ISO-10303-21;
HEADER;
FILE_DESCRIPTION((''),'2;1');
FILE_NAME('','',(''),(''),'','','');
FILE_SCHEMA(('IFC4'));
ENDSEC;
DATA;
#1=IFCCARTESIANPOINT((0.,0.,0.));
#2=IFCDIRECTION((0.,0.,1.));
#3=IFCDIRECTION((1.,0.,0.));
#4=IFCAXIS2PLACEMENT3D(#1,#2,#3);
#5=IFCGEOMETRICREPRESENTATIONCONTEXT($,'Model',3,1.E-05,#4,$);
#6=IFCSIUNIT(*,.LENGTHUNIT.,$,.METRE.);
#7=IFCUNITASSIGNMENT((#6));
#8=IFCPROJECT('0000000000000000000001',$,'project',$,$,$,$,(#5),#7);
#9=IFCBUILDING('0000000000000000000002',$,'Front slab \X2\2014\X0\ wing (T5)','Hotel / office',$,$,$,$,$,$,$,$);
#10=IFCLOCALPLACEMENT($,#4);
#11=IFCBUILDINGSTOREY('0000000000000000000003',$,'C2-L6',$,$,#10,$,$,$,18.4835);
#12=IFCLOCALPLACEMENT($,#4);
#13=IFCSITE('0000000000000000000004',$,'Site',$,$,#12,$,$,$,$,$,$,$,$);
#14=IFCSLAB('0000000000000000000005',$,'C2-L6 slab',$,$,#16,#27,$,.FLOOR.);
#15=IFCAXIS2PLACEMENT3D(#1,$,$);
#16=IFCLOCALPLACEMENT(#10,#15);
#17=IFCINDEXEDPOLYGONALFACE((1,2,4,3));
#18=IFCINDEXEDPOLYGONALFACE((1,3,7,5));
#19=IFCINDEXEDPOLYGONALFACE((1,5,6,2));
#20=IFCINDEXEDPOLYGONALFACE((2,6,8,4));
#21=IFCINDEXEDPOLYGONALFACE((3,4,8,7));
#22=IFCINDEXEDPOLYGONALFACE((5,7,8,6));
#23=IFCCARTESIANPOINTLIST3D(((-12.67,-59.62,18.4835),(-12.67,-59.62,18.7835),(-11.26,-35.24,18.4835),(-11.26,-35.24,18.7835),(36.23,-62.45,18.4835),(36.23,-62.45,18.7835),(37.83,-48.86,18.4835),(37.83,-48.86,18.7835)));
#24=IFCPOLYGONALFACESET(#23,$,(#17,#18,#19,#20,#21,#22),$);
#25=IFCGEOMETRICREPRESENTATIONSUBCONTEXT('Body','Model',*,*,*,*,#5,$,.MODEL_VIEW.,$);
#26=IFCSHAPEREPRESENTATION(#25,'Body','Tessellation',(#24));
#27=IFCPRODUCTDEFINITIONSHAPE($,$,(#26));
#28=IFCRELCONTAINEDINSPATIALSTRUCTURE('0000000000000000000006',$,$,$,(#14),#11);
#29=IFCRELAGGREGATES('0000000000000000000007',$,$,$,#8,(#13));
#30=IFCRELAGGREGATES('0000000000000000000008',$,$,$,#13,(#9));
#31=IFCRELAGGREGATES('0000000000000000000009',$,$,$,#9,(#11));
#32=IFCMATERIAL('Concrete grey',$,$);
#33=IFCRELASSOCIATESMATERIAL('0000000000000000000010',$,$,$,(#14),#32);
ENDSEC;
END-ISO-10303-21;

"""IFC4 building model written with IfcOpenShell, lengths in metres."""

from ifc_helpers import new_model, si_unit, frame, origin_with_axes, place, context, subcontext, project, spatial, polyline, outline, extrude, material, element, save


model = new_model("IFC4")

# Units and contexts
model_context = context("Model", 3, precision=1e-05, world=origin_with_axes())
body_context = subcontext(model_context, "Body", "Model", "MODEL_VIEW")
ifc_project = project(units=[si_unit("LENGTHUNIT", "METRE")], contexts=[model_context])

# Site, building, storey
site_placement = place(None, origin_with_axes())
site = spatial("IfcSite", under=ifc_project, at=site_placement, Name="Site")
building = spatial("IfcBuilding", under=site, Name="Front slab — wing (T5)", Description="Hotel / office")
storey_placement = place(None, origin_with_axes())
storey = spatial("IfcBuildingStorey", under=building, at=storey_placement, Name="C2-L6", Elevation=18.4835)

# Slab
ifc_material_1 = material(Name="Concrete grey")
slab_placement = place(storey_placement, origin_with_axes())
element("IfcSlab", 1, at=slab_placement, inside=storey, material=ifc_material_1, Name="C2-L6 slab", PredefinedType="FLOOR", context=body_context, shape_type="SweptSolid", body=[
    extrude(outline(polyline([(-11.26, -35.24), (-12.67, -59.62), (36.23, -62.45), (37.83, -48.86), (-11.26, -35.24)])), frame((0.0, 0.0, 18.4835), z_axis=(0.0, 0.0, 1.0), x_axis=(1.0, 0.0, 0.0)), (0.0, 0.0, 1.0), 0.3),
])

save(model, "model.ifc")
